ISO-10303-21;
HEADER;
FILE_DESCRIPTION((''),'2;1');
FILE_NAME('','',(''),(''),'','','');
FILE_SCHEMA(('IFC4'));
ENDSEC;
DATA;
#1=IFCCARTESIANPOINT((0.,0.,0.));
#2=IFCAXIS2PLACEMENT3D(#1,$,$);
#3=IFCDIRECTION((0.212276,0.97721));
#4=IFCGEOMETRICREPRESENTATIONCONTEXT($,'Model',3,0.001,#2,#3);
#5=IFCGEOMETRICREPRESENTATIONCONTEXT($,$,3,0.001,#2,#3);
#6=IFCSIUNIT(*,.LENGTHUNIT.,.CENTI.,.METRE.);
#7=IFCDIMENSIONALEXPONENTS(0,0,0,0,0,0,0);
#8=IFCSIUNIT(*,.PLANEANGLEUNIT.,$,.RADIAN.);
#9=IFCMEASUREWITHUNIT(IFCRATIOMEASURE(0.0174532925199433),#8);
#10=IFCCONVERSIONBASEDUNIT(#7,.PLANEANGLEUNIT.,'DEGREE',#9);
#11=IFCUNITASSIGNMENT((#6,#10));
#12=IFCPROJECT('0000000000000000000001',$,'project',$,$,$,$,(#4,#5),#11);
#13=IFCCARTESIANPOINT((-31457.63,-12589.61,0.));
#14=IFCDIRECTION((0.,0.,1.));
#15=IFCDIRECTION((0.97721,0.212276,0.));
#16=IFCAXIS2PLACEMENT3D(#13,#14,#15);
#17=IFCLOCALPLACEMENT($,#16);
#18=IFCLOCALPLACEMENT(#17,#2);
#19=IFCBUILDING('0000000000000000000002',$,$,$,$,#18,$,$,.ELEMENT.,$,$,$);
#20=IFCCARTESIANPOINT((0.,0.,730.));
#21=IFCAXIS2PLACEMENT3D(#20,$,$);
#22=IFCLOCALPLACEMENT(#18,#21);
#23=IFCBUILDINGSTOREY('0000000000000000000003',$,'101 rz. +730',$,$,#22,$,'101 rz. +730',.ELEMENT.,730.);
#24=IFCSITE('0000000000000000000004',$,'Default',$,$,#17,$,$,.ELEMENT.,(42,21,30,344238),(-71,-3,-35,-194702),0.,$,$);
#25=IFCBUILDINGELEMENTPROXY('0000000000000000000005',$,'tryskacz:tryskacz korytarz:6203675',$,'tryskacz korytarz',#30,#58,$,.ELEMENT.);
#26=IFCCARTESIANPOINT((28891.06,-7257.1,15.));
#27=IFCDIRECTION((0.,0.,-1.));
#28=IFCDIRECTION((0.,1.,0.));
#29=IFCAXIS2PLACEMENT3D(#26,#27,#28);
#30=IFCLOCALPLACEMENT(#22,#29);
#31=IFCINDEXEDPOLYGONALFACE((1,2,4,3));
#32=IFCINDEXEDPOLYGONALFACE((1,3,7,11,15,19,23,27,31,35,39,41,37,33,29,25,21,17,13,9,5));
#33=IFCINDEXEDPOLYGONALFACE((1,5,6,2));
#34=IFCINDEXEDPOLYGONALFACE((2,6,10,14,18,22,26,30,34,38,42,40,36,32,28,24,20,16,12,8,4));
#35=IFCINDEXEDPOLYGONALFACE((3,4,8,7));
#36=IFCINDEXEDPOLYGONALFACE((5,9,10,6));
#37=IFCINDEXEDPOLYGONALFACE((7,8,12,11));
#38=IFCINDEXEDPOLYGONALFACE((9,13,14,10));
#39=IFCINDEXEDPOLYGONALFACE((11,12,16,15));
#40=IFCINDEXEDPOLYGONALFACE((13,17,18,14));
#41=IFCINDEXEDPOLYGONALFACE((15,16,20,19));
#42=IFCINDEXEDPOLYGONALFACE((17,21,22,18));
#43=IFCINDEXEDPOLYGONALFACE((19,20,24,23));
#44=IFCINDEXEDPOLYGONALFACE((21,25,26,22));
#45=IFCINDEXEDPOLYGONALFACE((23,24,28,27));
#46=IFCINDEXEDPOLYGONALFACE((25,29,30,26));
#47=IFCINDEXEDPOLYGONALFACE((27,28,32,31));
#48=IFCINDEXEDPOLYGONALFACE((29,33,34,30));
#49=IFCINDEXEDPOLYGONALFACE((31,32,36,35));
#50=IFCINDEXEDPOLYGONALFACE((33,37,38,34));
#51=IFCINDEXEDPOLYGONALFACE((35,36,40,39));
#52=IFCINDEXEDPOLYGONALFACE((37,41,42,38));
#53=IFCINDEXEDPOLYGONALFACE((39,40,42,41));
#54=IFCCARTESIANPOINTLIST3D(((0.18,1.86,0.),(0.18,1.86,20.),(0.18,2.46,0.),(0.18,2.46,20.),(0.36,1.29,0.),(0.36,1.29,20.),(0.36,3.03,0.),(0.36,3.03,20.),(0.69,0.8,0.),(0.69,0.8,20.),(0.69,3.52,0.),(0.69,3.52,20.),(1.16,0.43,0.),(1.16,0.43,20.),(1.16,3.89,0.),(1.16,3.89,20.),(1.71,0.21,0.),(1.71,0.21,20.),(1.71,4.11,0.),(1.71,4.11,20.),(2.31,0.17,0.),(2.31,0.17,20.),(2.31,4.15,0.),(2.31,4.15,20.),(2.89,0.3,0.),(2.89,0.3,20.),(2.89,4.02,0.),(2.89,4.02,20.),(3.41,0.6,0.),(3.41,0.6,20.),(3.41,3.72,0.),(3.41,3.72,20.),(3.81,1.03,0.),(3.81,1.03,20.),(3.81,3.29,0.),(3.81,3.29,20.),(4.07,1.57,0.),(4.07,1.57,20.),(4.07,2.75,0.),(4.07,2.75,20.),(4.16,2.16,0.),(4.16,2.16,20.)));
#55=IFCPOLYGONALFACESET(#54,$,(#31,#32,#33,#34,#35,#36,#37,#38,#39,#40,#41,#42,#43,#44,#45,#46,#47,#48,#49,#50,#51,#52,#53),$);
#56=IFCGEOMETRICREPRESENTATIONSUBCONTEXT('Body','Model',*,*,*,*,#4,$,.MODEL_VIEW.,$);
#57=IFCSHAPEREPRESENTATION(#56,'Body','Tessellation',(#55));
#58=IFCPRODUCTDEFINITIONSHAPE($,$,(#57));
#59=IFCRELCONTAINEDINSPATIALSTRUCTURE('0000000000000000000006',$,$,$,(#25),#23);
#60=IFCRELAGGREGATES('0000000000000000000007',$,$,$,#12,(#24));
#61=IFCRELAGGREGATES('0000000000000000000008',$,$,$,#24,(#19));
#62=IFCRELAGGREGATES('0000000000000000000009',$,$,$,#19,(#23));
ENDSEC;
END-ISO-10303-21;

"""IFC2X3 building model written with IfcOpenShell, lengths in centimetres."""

from ifc_helpers import new_model, entity, si_unit, converted_unit, direction, frame, frame_2d, origin, place, context, subcontext, project, spatial, circle, extrude, source, transform, mapped, element, save


model = new_model("IFC2X3")

# Units and contexts
model_context = context("Model", 3, precision=0.001, world=origin(), true_north=direction((0.212276, 0.97721)))
context_of_model = context(None, 3, precision=0.001, world=origin(), true_north=direction((0.212276, 0.97721)))
body_context = subcontext(model_context, "Body", "Model", "MODEL_VIEW")
ifc_project = project(units=[si_unit("LENGTHUNIT", "METRE", prefix="CENTI"), converted_unit("PLANEANGLEUNIT", "DEGREE", entity("IfcRatioMeasure", 0.0174532925199433), si_unit("PLANEANGLEUNIT", "RADIAN"), dimensions=[0, 0, 0, 0, 0, 0, 0])], contexts=[model_context, context_of_model])

# Site, building, storey
site_placement = place(None, frame((-31457.63, -12589.61, 0.0), z_axis=(0.0, 0.0, 1.0), x_axis=(0.97721, 0.212276, 0.0)))
site = spatial("IfcSite", under=ifc_project, at=site_placement, Name="Default", CompositionType="ELEMENT", RefLatitude=(42, 21, 30, 344238), RefLongitude=(-71, -3, -35, -194702), RefElevation=0.0)
building_placement = place(site_placement, origin())
building = spatial("IfcBuilding", under=site, at=building_placement, CompositionType="ELEMENT")
storey_placement = place(building_placement, frame((0.0, 0.0, 730.0)))
storey = spatial("IfcBuildingStorey", under=building, at=storey_placement, Name="101 rz. +730", LongName="101 rz. +730", CompositionType="ELEMENT", Elevation=730.0)

# Building element proxy
shared_shape_1 = source(origin(), body_context, "Body", "SweptSolid", [
    extrude(circle(Radius=2.0, at=frame_2d((0.0, 0.0), x_axis=(1.0, 0.0))), frame((2.16, 2.16, 0.0)), (0.0, 0.0, 1.0), 20.0),
])
for number, where, z_axis, x_axis, name in (
    (1, (28891.06, -7257.1, 15.0), (0.0, 0.0, -1.0), (0.0, 1.0, 0.0), "tryskacz:tryskacz korytarz:6203675"),
):
    element("IfcBuildingElementProxy", number, at=place(storey_placement, frame(where, z_axis=z_axis, x_axis=x_axis)), inside=storey, Name=name, ObjectType="tryskacz korytarz", CompositionType="ELEMENT", context=body_context, shape_type="MappedRepresentation", body=[
        mapped(shared_shape_1, transform((0.0, 0.0, 0.0), scale=1.0)),
    ])

save(model, "model.ifc")
